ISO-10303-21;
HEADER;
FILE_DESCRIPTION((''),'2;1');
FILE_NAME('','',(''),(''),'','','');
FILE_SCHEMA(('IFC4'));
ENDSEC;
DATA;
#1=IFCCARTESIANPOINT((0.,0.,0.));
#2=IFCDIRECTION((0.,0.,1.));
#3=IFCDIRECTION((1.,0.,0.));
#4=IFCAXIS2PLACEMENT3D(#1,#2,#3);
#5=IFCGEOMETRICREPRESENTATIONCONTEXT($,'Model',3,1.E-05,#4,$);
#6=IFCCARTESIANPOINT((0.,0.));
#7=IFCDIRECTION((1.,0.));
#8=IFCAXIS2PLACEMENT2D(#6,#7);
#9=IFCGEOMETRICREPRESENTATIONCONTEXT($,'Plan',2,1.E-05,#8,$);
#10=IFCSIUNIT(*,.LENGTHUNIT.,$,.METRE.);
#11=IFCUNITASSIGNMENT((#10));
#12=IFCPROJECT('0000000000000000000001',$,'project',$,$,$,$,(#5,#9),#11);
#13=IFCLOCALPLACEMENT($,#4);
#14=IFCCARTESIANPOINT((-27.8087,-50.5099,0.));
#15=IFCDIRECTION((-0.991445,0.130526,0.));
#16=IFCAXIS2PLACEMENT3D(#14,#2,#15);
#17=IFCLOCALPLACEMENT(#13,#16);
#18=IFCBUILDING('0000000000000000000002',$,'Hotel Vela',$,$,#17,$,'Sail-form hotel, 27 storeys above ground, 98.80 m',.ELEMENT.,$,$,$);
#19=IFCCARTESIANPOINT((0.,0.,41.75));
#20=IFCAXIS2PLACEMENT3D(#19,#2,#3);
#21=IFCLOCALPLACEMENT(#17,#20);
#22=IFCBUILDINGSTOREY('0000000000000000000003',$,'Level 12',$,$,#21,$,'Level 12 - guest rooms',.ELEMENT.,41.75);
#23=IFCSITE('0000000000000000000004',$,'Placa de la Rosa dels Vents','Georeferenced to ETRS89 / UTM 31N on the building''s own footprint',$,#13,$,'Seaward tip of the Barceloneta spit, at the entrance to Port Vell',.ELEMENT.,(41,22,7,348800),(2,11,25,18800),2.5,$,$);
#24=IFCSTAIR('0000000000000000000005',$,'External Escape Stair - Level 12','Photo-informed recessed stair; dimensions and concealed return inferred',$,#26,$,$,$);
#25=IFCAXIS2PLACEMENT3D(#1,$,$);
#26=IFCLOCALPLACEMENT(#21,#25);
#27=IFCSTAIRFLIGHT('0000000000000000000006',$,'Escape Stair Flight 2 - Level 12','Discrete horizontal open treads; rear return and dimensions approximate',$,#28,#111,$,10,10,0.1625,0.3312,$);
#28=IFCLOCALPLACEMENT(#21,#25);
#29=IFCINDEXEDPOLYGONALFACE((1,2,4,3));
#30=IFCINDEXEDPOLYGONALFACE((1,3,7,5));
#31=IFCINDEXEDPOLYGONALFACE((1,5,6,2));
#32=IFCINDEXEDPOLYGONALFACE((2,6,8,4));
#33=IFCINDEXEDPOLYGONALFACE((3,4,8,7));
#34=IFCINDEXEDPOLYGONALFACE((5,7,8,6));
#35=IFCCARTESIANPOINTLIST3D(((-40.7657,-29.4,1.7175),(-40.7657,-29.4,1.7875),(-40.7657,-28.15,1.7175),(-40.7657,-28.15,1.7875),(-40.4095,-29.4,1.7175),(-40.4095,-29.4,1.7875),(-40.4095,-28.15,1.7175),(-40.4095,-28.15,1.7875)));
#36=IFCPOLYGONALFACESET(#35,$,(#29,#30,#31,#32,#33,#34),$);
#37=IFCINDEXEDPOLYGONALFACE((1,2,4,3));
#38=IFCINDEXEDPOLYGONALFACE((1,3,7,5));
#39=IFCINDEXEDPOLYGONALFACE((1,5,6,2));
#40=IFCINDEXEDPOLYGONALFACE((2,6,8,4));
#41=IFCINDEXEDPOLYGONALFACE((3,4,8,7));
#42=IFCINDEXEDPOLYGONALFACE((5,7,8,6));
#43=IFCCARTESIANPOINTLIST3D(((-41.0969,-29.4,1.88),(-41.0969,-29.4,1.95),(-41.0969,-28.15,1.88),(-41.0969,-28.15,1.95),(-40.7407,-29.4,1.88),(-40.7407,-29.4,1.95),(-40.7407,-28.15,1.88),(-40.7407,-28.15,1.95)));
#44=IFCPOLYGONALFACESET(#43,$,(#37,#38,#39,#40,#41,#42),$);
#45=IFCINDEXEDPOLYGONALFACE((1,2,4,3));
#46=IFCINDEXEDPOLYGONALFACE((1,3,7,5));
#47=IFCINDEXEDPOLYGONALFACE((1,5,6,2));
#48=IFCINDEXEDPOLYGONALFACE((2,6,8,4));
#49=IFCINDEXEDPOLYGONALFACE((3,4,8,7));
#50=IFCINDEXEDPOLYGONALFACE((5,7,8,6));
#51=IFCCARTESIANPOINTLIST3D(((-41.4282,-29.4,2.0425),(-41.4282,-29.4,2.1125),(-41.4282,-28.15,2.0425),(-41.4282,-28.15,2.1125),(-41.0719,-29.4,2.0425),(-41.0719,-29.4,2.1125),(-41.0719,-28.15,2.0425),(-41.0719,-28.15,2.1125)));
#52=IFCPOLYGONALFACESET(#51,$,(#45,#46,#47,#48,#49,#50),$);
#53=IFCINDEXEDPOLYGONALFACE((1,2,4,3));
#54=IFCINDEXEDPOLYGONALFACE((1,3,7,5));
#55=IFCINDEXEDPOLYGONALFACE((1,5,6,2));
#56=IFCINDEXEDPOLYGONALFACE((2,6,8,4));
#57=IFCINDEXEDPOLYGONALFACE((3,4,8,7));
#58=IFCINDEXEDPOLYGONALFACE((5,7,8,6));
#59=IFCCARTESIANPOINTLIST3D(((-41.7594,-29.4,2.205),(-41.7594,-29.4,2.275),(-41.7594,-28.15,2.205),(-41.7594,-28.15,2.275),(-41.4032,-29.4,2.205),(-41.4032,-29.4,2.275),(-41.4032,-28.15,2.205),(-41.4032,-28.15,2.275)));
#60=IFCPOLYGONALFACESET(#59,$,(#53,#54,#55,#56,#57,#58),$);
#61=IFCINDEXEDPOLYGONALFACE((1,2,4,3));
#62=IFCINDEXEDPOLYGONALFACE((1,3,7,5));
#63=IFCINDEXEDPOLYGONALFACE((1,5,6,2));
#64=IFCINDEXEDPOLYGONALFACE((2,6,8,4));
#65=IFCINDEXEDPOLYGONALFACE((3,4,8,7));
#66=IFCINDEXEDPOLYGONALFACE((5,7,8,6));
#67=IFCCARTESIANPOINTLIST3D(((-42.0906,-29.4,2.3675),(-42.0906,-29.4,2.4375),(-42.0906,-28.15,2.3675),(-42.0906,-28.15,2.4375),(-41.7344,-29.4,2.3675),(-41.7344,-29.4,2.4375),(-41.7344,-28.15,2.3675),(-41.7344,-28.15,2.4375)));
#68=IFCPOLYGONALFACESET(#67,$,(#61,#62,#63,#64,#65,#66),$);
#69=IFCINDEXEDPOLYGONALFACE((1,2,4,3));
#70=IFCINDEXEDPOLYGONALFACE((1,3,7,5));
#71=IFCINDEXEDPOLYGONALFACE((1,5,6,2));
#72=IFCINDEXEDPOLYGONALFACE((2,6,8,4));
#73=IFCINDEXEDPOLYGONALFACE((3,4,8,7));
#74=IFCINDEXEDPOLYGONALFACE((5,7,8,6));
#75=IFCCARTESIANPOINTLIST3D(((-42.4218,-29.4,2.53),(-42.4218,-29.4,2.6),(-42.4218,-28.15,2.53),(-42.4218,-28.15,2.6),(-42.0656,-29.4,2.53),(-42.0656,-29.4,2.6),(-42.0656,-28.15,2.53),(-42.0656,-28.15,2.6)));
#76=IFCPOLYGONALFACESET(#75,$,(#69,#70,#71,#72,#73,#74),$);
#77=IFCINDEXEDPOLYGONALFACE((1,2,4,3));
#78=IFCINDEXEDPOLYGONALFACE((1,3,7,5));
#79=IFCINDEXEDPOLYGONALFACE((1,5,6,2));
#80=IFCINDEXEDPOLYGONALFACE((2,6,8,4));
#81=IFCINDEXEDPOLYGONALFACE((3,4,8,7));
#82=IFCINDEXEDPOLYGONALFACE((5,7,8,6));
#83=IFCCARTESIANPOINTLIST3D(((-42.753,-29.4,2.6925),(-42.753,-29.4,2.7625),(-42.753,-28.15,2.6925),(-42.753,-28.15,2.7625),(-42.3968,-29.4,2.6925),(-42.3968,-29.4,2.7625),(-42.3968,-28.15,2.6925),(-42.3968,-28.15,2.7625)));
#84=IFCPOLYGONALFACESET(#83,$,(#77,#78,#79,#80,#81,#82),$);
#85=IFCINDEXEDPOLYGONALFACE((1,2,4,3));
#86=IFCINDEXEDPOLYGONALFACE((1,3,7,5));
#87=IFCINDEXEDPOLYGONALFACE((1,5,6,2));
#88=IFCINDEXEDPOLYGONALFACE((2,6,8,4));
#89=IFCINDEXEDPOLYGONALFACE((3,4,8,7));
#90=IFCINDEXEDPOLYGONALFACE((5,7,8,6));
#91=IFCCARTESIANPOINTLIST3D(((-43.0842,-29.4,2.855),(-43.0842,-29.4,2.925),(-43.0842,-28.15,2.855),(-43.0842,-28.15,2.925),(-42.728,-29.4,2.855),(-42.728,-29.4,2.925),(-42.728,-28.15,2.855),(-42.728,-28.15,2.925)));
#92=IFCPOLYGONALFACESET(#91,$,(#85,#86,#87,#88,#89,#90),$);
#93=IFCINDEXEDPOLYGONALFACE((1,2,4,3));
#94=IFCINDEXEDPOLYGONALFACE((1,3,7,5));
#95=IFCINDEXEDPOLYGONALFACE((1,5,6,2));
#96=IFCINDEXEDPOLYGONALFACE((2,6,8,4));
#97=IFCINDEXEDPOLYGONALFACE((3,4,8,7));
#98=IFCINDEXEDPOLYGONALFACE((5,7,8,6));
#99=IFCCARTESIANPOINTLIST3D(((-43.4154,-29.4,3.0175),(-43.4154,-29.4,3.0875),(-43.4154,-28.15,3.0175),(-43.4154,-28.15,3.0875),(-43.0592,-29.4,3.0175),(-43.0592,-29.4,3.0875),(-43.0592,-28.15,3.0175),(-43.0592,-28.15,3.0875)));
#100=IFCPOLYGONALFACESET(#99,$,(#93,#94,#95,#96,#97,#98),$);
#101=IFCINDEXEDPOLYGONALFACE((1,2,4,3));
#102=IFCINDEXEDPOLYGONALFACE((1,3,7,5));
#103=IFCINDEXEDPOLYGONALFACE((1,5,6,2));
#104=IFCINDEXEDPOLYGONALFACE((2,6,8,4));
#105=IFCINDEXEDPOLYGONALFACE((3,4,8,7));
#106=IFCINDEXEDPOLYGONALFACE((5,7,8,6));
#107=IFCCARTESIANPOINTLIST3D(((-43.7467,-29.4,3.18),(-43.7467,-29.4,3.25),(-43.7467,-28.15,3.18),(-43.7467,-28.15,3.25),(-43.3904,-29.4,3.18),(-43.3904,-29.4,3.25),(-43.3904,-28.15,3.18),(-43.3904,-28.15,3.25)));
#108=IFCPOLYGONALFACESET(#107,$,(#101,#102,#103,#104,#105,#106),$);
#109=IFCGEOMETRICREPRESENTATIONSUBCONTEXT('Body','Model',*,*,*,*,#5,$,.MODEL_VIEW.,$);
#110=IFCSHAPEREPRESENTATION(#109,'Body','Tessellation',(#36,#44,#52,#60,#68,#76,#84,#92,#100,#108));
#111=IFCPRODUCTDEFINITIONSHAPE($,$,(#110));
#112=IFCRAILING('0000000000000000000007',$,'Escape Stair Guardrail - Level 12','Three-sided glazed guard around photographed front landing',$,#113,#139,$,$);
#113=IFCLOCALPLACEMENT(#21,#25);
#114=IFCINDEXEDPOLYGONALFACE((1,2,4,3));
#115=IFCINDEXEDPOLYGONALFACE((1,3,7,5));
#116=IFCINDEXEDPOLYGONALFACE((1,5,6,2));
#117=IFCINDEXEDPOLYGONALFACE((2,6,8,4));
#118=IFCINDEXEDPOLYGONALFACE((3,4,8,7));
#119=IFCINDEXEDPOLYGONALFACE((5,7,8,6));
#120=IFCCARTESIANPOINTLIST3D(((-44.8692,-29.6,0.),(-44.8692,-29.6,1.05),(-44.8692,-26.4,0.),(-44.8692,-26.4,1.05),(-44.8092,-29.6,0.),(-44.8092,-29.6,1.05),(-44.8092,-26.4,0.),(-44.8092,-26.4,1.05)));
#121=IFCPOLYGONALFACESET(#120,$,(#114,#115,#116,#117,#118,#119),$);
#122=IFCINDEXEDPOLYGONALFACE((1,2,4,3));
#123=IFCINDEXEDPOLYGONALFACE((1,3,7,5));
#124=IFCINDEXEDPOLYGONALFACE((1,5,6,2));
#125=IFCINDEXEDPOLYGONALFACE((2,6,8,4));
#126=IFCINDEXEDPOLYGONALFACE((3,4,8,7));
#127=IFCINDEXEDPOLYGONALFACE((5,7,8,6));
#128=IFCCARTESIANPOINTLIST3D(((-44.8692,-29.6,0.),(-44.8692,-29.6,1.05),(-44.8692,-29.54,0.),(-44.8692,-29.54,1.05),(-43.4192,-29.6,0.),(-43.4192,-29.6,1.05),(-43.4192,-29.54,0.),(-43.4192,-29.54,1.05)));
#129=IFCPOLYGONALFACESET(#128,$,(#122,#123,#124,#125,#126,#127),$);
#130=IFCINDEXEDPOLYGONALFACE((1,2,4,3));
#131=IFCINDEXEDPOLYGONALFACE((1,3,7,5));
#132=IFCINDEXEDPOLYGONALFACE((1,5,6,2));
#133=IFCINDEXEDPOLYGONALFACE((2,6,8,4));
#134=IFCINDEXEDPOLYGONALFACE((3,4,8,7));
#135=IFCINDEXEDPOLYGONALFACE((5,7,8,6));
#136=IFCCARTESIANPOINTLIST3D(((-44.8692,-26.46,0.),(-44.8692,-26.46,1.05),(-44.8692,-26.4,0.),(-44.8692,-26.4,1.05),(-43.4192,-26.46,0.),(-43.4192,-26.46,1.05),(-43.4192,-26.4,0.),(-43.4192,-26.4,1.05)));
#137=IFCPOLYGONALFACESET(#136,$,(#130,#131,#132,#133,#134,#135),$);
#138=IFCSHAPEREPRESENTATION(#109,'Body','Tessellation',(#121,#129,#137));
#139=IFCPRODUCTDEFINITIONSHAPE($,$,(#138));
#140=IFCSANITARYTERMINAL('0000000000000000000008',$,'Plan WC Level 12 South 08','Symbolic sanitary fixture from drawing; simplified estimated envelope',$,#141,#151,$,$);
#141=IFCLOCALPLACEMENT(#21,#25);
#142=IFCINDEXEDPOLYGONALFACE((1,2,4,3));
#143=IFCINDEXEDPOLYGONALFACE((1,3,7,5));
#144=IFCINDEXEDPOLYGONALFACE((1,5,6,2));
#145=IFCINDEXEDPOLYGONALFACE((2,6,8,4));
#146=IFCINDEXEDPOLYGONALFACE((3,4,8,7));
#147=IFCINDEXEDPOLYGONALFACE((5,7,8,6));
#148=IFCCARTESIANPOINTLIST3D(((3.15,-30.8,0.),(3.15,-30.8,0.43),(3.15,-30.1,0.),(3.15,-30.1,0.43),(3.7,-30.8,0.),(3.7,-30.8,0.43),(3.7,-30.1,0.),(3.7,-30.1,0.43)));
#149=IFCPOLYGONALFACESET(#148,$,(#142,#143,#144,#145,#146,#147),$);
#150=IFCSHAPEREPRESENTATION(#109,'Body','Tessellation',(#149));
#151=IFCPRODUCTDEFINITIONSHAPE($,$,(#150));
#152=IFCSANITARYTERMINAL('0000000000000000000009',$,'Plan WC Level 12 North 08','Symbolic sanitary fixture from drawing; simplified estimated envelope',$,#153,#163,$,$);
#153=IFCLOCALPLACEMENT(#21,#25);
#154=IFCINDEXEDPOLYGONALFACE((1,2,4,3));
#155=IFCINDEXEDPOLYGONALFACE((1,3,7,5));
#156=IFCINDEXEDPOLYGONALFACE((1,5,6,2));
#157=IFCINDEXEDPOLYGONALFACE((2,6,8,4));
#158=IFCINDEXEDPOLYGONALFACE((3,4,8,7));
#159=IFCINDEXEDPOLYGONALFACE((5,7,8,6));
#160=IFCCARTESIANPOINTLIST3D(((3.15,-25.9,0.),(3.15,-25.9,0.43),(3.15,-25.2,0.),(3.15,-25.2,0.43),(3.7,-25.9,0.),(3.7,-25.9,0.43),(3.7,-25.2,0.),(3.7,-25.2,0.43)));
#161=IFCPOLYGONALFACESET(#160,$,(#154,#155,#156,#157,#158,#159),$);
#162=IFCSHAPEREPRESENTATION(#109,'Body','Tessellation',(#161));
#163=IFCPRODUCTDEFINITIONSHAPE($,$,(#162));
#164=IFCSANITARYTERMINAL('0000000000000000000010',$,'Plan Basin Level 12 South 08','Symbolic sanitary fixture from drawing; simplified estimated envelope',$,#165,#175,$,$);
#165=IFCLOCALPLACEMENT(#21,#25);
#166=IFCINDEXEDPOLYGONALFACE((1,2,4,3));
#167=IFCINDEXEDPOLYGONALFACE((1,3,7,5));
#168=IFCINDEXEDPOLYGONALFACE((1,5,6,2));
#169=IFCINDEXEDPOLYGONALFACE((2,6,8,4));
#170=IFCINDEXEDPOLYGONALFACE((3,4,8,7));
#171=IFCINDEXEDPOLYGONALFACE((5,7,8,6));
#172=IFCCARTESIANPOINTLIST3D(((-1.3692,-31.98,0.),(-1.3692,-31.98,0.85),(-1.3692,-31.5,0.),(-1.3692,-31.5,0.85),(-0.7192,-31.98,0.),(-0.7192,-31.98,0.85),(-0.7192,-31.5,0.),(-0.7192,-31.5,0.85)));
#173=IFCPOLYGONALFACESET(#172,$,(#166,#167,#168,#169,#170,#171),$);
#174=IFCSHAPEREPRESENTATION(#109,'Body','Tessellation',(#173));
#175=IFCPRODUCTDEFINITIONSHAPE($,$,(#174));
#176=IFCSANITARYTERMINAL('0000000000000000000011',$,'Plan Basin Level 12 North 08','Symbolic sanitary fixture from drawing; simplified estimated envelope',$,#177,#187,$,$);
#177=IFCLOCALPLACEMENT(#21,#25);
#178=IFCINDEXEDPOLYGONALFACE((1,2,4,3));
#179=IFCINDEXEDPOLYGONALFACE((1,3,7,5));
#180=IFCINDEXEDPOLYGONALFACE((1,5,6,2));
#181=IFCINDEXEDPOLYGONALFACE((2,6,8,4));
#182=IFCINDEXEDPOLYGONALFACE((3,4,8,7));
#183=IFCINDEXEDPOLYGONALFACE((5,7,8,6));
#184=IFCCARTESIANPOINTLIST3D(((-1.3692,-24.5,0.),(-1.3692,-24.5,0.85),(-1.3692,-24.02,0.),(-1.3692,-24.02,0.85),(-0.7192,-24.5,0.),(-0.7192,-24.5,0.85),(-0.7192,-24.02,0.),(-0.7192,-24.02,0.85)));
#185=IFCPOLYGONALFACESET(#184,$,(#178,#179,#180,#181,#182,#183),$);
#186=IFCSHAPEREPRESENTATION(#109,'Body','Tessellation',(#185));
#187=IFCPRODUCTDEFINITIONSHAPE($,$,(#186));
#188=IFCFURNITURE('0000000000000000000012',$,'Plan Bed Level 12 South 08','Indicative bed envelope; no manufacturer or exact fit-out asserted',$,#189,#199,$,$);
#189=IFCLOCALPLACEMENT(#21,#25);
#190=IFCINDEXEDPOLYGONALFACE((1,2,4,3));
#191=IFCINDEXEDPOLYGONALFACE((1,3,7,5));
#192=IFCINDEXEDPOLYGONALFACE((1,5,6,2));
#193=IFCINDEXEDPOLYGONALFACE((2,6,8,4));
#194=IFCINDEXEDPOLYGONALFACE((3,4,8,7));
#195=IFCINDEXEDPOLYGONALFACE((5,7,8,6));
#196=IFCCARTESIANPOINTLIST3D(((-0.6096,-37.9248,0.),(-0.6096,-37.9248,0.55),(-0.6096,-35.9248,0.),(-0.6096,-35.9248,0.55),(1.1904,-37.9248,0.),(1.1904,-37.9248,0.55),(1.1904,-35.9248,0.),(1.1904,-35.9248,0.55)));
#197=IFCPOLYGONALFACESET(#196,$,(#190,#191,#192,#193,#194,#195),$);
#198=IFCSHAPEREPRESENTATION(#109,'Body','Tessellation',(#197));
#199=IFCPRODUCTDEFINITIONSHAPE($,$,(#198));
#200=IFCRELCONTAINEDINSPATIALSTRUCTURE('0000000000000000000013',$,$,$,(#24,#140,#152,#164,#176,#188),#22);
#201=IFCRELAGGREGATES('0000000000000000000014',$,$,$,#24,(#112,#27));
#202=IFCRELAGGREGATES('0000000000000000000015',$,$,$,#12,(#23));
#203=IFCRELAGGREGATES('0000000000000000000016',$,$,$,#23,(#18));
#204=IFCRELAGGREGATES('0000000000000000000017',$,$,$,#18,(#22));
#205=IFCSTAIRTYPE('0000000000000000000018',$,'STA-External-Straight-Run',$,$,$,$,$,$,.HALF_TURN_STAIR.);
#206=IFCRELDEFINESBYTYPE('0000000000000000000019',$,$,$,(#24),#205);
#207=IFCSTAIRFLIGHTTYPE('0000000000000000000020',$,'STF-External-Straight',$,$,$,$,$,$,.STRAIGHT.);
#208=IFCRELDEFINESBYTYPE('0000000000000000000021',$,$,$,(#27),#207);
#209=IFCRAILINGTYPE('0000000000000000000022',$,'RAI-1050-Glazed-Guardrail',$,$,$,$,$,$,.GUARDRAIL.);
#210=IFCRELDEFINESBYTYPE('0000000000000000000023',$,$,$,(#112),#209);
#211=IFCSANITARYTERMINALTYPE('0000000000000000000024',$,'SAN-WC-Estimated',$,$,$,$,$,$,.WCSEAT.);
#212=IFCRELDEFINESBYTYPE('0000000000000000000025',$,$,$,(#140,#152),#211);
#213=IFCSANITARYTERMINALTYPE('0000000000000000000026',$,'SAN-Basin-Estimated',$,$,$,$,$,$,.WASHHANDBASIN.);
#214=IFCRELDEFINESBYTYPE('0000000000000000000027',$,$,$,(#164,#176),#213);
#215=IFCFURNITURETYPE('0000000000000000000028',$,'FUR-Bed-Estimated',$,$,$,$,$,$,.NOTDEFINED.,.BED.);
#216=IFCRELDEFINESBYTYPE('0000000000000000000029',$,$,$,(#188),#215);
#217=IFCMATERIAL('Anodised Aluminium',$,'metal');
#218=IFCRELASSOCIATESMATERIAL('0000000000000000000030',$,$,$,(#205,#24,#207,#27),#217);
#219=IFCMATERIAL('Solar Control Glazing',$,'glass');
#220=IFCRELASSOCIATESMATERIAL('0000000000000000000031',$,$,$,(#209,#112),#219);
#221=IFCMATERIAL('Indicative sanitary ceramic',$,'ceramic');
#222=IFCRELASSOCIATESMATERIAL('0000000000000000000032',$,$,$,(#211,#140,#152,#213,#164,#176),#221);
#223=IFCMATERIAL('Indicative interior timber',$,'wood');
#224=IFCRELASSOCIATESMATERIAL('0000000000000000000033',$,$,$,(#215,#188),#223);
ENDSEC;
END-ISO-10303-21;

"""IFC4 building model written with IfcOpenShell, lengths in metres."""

from ifc_helpers import new_model, si_unit, frame, origin_with_axes, origin_2d_with_axis, place, context, subcontext, project, spatial, line, indexed_curve, outline, extrude, material, type_object, element, aggregate, save


model = new_model("IFC4")

# Units and contexts
model_context = context("Model", 3, precision=1e-05, world=origin_with_axes())
plan_context = context("Plan", 2, precision=1e-05, world=origin_2d_with_axis())
body_context = subcontext(model_context, "Body", "Model", "MODEL_VIEW")
ifc_project = project(units=[si_unit("LENGTHUNIT", "METRE")], contexts=[model_context, plan_context])

# Site, building, storey
site_placement = place(None, origin_with_axes())
site = spatial("IfcSite", under=ifc_project, at=site_placement, Name="Placa de la Rosa dels Vents", Description="Georeferenced to ETRS89 / UTM 31N on the building's own footprint", LongName="Seaward tip of the Barceloneta spit, at the entrance to Port Vell", CompositionType="ELEMENT", RefLatitude=(41, 22, 7, 348800), RefLongitude=(2, 11, 25, 18800), RefElevation=2.5)
building_placement = place(site_placement, frame((-27.8087, -50.5099, 0.0), z_axis=(0.0, 0.0, 1.0), x_axis=(-0.991445, 0.130526, 0.0)))
building = spatial("IfcBuilding", under=site, at=building_placement, Name="Hotel Vela", LongName="Sail-form hotel, 27 storeys above ground, 98.80 m", CompositionType="ELEMENT")
storey_placement = place(building_placement, frame((0.0, 0.0, 41.75), z_axis=(0.0, 0.0, 1.0), x_axis=(1.0, 0.0, 0.0)))
storey = spatial("IfcBuildingStorey", under=building, at=storey_placement, Name="Level 12", LongName="Level 12 - guest rooms", CompositionType="ELEMENT", Elevation=41.75)

# Stair
ifc_material_1 = material(Name="Anodised Aluminium", Category="metal")
stair_type = type_object("IfcStairType", Name="STA-External-Straight-Run", PredefinedType="HALF_TURN_STAIR", material=ifc_material_1)
stair_placement = place(storey_placement, frame((0.0, 0.0, -41.75), z_axis=(0.0, 0.0, 1.0), x_axis=(1.0, 0.0, 0.0)))
stair = element("IfcStair", 1, at=stair_placement, inside=storey, type_object=stair_type, material=ifc_material_1, Name="External Escape Stair - Level 12", Description="Photo-informed recessed stair; dimensions and concealed return inferred")

# Shared definitions
ifc_material_2 = material(Name="Indicative interior timber", Category="wood")

# Stair flight
stair_flight_type = type_object("IfcStairFlightType", Name="STF-External-Straight", PredefinedType="STRAIGHT", material=ifc_material_1)
stair_flight_1_placement = place(stair_placement, origin_with_axes())
stair_flight_1 = element("IfcStairFlight", 2, at=stair_flight_1_placement, type_object=stair_flight_type, material=ifc_material_1, Name="Escape Stair Flight 2 - Level 12", Description="Discrete horizontal open treads; rear return and dimensions approximate", NumberOfRisers=10, NumberOfTreads=10, RiserHeight=0.1625, TreadLength=0.3312, context=body_context, shape_type="SweptSolid", body=[
    extrude(outline(indexed_curve([(0.0, 0.0), (0.3562, 0.0), (0.3562, 1.25), (0.0, 1.25)], segments=[line(1, 2, 3, 4, 1)])), frame((-40.7657, -29.4, 43.4675), z_axis=(0.0, 0.0, 1.0), x_axis=(1.0, 0.0, 0.0)), (0.0, 0.0, 1.0), 0.07),
    extrude(outline(indexed_curve([(0.0, 0.0), (0.3562, 0.0), (0.3562, 1.25), (0.0, 1.25)], segments=[line(1, 2, 3, 4, 1)])), frame((-41.0969, -29.4, 43.63), z_axis=(0.0, 0.0, 1.0), x_axis=(1.0, 0.0, 0.0)), (0.0, 0.0, 1.0), 0.07),
    extrude(outline(indexed_curve([(0.0, 0.0), (0.3562, 0.0), (0.3562, 1.25), (0.0, 1.25)], segments=[line(1, 2, 3, 4, 1)])), frame((-41.4282, -29.4, 43.7925), z_axis=(0.0, 0.0, 1.0), x_axis=(1.0, 0.0, 0.0)), (0.0, 0.0, 1.0), 0.07),
    extrude(outline(indexed_curve([(0.0, 0.0), (0.3562, 0.0), (0.3562, 1.25), (0.0, 1.25)], segments=[line(1, 2, 3, 4, 1)])), frame((-41.7594, -29.4, 43.955), z_axis=(0.0, 0.0, 1.0), x_axis=(1.0, 0.0, 0.0)), (0.0, 0.0, 1.0), 0.07),
    extrude(outline(indexed_curve([(0.0, 0.0), (0.3562, 0.0), (0.3562, 1.25), (0.0, 1.25)], segments=[line(1, 2, 3, 4, 1)])), frame((-42.0906, -29.4, 44.1175), z_axis=(0.0, 0.0, 1.0), x_axis=(1.0, 0.0, 0.0)), (0.0, 0.0, 1.0), 0.07),
    extrude(outline(indexed_curve([(0.0, 0.0), (0.3562, 0.0), (0.3562, 1.25), (0.0, 1.25)], segments=[line(1, 2, 3, 4, 1)])), frame((-42.4218, -29.4, 44.28), z_axis=(0.0, 0.0, 1.0), x_axis=(1.0, 0.0, 0.0)), (0.0, 0.0, 1.0), 0.07),
    extrude(outline(indexed_curve([(0.0, 0.0), (0.3562, 0.0), (0.3562, 1.25), (0.0, 1.25)], segments=[line(1, 2, 3, 4, 1)])), frame((-42.753, -29.4, 44.4425), z_axis=(0.0, 0.0, 1.0), x_axis=(1.0, 0.0, 0.0)), (0.0, 0.0, 1.0), 0.07),
    extrude(outline(indexed_curve([(0.0, 0.0), (0.3562, 0.0), (0.3562, 1.25), (0.0, 1.25)], segments=[line(1, 2, 3, 4, 1)])), frame((-43.0842, -29.4, 44.605), z_axis=(0.0, 0.0, 1.0), x_axis=(1.0, 0.0, 0.0)), (0.0, 0.0, 1.0), 0.07),
    extrude(outline(indexed_curve([(0.0, 0.0), (0.3562, 0.0), (0.3562, 1.25), (0.0, 1.25)], segments=[line(1, 2, 3, 4, 1)])), frame((-43.4154, -29.4, 44.7675), z_axis=(0.0, 0.0, 1.0), x_axis=(1.0, 0.0, 0.0)), (0.0, 0.0, 1.0), 0.07),
    extrude(outline(indexed_curve([(0.0, 0.0), (0.3562, 0.0), (0.3562, 1.25), (0.0, 1.25)], segments=[line(1, 2, 3, 4, 1)])), frame((-43.7467, -29.4, 44.93), z_axis=(0.0, 0.0, 1.0), x_axis=(1.0, 0.0, 0.0)), (0.0, 0.0, 1.0), 0.07),
])

# Railing
ifc_material_3 = material(Name="Solar Control Glazing", Category="glass")
railing_type = type_object("IfcRailingType", Name="RAI-1050-Glazed-Guardrail", PredefinedType="GUARDRAIL", material=ifc_material_3)
railing_placement = place(stair_placement, origin_with_axes())
railing = element("IfcRailing", 3, at=railing_placement, type_object=railing_type, material=ifc_material_3, Name="Escape Stair Guardrail - Level 12", Description="Three-sided glazed guard around photographed front landing", context=body_context, shape_type="SweptSolid", body=[
    extrude(outline(indexed_curve([(0.0, 0.0), (0.06, 0.0), (0.06, 3.2), (0.0, 3.2)], segments=[line(1, 2, 3, 4, 1)])), frame((-44.8692, -29.6, 41.75), z_axis=(0.0, 0.0, 1.0), x_axis=(1.0, 0.0, 0.0)), (0.0, 0.0, 1.0), 1.05),
    extrude(outline(indexed_curve([(0.0, 0.0), (1.45, 0.0), (1.45, 0.06), (0.0, 0.06)], segments=[line(1, 2, 3, 4, 1)])), frame((-44.8692, -29.6, 41.75), z_axis=(0.0, 0.0, 1.0), x_axis=(1.0, 0.0, 0.0)), (0.0, 0.0, 1.0), 1.05),
    extrude(outline(indexed_curve([(0.0, 0.0), (1.45, 0.0), (1.45, 0.06), (0.0, 0.06)], segments=[line(1, 2, 3, 4, 1)])), frame((-44.8692, -26.46, 41.75), z_axis=(0.0, 0.0, 1.0), x_axis=(1.0, 0.0, 0.0)), (0.0, 0.0, 1.0), 1.05),
])
aggregate(stair, [railing, stair_flight_1])

# Sanitary terminals
ifc_material_4 = material(Name="Indicative sanitary ceramic", Category="ceramic")
sanitary_terminal_type_1 = type_object("IfcSanitaryTerminalType", Name="SAN-WC-Estimated", PredefinedType="WCSEAT", material=ifc_material_4)
for number, where, z_axis, x_axis, name in (
    (4, (3.15, -30.8, 0.0), (0.0, 0.0, 1.0), (1.0, 0.0, 0.0), "Plan WC Level 12 South 08"),
    (5, (3.15, -25.9, 0.0), (0.0, 0.0, 1.0), (1.0, 0.0, 0.0), "Plan WC Level 12 North 08"),
):
    element("IfcSanitaryTerminal", number, at=place(storey_placement, frame(where, z_axis=z_axis, x_axis=x_axis)), inside=storey, type_object=sanitary_terminal_type_1, material=ifc_material_4, Name=name, Description="Symbolic sanitary fixture from drawing; simplified estimated envelope", context=body_context, shape_type="SweptSolid", body=[
        extrude(outline(indexed_curve([(0.0, 0.0), (0.55, 0.0), (0.55, 0.7), (0.0, 0.7)], segments=[line(1, 2, 3, 4, 1)])), origin_with_axes(), (0.0, 0.0, 1.0), 0.43),
    ])
sanitary_terminal_type_2 = type_object("IfcSanitaryTerminalType", Name="SAN-Basin-Estimated", PredefinedType="WASHHANDBASIN", material=ifc_material_4)
for number, where, z_axis, x_axis, name in (
    (6, (-1.3692, -31.98, 0.0), (0.0, 0.0, 1.0), (1.0, 0.0, 0.0), "Plan Basin Level 12 South 08"),
    (7, (-1.3692, -24.5, 0.0), (0.0, 0.0, 1.0), (1.0, 0.0, 0.0), "Plan Basin Level 12 North 08"),
):
    element("IfcSanitaryTerminal", number, at=place(storey_placement, frame(where, z_axis=z_axis, x_axis=x_axis)), inside=storey, type_object=sanitary_terminal_type_2, material=ifc_material_4, Name=name, Description="Symbolic sanitary fixture from drawing; simplified estimated envelope", context=body_context, shape_type="SweptSolid", body=[
        extrude(outline(indexed_curve([(0.0, 0.0), (0.65, 0.0), (0.65, 0.48), (0.0, 0.48)], segments=[line(1, 2, 3, 4, 1)])), origin_with_axes(), (0.0, 0.0, 1.0), 0.85),
    ])

# Furniture
furniture_type = type_object("IfcFurnitureType", Name="FUR-Bed-Estimated", AssemblyPlace="NOTDEFINED", PredefinedType="BED", material=ifc_material_2)
for number, where, z_axis, x_axis, name in (
    (8, (-0.6096, -37.9248, 0.0), (0.0, 0.0, 1.0), (1.0, 0.0, 0.0), "Plan Bed Level 12 South 08"),
):
    element("IfcFurniture", number, at=place(storey_placement, frame(where, z_axis=z_axis, x_axis=x_axis)), inside=storey, type_object=furniture_type, material=ifc_material_2, Name=name, Description="Indicative bed envelope; no manufacturer or exact fit-out asserted", context=body_context, shape_type="SweptSolid", body=[
        extrude(outline(indexed_curve([(0.0, 0.0), (1.8, 0.0), (1.8, 2.0), (0.0, 2.0)], segments=[line(1, 2, 3, 4, 1)])), origin_with_axes(), (0.0, 0.0, 1.0), 0.55),
    ])

save(model, "model.ifc")
